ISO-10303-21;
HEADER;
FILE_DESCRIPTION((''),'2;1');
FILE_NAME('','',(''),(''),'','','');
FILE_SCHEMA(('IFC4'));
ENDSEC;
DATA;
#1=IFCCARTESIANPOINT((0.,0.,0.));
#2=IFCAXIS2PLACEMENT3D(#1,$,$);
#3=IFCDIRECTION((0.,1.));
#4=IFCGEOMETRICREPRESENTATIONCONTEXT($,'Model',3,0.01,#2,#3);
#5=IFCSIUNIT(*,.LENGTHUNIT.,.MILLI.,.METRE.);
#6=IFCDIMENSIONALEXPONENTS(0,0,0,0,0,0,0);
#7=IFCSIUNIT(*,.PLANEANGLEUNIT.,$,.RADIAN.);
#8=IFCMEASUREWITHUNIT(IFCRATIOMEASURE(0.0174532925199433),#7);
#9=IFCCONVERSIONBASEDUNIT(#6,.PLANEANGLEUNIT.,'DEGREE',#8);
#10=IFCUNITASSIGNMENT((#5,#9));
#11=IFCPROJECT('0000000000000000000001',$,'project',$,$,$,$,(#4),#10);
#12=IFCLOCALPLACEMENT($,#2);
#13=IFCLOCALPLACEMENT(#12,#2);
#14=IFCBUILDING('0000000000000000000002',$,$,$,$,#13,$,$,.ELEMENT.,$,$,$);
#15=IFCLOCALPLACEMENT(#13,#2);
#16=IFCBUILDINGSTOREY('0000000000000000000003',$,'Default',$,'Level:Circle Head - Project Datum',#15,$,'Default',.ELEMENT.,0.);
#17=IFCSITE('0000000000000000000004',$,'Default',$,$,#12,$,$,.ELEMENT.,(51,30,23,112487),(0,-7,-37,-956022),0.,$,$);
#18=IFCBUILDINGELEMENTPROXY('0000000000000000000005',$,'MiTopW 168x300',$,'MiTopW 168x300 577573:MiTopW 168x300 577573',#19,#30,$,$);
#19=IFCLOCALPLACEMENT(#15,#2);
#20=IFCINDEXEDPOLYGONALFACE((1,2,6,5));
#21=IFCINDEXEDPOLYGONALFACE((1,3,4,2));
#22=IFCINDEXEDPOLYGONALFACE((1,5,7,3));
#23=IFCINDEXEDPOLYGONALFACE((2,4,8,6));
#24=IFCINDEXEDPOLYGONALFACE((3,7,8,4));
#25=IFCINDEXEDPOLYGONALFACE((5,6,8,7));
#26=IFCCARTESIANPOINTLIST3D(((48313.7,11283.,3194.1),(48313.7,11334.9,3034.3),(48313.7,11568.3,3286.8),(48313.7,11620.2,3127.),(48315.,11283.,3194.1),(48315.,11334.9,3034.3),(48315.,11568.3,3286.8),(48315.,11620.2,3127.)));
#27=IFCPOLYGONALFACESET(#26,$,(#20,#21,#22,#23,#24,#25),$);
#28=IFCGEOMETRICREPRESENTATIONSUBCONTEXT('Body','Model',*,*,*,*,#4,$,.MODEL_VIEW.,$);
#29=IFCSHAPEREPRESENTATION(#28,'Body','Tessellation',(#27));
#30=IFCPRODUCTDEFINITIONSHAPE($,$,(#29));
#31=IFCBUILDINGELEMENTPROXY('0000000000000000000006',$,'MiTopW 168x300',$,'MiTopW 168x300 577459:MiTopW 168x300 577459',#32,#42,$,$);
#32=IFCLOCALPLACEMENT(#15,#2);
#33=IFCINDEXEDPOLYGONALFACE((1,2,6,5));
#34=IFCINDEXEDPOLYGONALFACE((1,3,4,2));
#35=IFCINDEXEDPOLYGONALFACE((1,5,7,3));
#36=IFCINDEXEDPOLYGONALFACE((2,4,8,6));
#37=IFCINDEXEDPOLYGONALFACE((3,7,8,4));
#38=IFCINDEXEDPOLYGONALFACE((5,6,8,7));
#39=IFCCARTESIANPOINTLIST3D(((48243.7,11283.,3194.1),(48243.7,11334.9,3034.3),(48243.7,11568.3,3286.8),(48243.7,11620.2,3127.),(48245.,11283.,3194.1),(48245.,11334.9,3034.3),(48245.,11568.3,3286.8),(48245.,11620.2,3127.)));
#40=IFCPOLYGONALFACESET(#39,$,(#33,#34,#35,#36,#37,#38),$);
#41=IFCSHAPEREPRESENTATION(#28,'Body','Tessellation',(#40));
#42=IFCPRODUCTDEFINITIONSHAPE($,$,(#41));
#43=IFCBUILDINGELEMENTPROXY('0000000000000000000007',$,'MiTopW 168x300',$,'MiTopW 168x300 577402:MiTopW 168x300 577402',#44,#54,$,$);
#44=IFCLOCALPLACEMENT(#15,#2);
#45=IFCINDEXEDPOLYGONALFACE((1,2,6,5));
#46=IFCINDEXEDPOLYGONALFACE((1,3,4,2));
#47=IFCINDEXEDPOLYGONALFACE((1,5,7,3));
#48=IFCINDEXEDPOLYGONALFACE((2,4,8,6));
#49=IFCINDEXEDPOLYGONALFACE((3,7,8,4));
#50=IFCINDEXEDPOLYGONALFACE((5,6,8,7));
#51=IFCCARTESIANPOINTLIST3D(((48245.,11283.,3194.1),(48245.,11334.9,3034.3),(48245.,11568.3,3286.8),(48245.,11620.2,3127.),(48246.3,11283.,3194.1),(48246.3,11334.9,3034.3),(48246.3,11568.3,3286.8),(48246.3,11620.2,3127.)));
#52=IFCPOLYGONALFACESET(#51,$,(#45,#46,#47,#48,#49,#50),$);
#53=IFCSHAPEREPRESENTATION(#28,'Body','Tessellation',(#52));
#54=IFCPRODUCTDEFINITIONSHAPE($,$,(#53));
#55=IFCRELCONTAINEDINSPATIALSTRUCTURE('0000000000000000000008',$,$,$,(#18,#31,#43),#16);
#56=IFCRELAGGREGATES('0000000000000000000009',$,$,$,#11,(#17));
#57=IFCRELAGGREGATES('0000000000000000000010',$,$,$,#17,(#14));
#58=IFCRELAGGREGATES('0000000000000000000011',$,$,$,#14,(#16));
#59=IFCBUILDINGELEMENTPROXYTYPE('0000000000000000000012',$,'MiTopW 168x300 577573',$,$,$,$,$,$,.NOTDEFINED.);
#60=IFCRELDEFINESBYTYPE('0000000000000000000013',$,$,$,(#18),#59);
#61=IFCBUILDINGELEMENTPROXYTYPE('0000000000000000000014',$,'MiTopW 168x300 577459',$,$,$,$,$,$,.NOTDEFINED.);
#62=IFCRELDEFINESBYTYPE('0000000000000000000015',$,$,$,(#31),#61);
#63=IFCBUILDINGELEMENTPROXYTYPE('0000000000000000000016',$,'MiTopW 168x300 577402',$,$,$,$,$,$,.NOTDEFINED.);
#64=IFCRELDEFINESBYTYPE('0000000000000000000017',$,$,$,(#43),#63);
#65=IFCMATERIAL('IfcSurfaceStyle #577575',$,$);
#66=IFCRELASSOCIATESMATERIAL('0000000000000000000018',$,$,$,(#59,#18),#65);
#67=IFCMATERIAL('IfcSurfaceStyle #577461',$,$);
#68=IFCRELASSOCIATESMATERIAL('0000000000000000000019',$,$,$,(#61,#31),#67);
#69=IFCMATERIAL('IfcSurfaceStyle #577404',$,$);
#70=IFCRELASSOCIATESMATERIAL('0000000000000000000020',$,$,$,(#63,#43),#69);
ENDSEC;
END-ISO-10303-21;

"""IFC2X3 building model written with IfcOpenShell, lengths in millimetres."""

from ifc_helpers import new_model, entity, si_unit, converted_unit, direction, frame, origin, place, context, subcontext, project, spatial, polyline, outline, extrude, source, transform, mapped, material, type_object, type_shapes, element, save


model = new_model("IFC2X3")

# Units and contexts
model_context = context("Model", 3, precision=0.01, world=origin(), true_north=direction((0.0, 1.0)))
body_context = subcontext(model_context, "Body", "Model", "MODEL_VIEW")
ifc_project = project(units=[si_unit("LENGTHUNIT", "METRE", prefix="MILLI"), converted_unit("PLANEANGLEUNIT", "DEGREE", entity("IfcRatioMeasure", 0.0174532925199433), si_unit("PLANEANGLEUNIT", "RADIAN"), dimensions=[0, 0, 0, 0, 0, 0, 0])], contexts=[model_context])

# Site, building, storey
site_placement = place(None, origin())
site = spatial("IfcSite", under=ifc_project, at=site_placement, Name="Default", CompositionType="ELEMENT", RefLatitude=(51, 30, 23, 112487), RefLongitude=(0, -7, -37, -956022), RefElevation=0.0)
building_placement = place(site_placement, origin())
building = spatial("IfcBuilding", under=site, at=building_placement, CompositionType="ELEMENT")
storey_placement = place(building_placement, origin())
storey = spatial("IfcBuildingStorey", under=building, at=storey_placement, Name="Default", ObjectType="Level:Circle Head - Project Datum", LongName="Default", CompositionType="ELEMENT", Elevation=0.0)

# Building element proxies
ifc_material_1 = material(Name="IfcSurfaceStyle #577575")
building_element_proxy_type_1 = type_object("IfcBuildingElementProxyType", Name="MiTopW 168x300 577573", PredefinedType="NOTDEFINED", material=ifc_material_1)
shared_shape_1 = source(origin(), body_context, "Body", "SweptSolid", [
    extrude(outline(polyline([(-150.0, -84.0), (150.0, -84.0), (150.0, 84.0), (-150.0, 84.0), (-150.0, -84.0)])), frame((150.0, 84.0, 0.0), z_axis=(0.0, 0.0, 1.0), x_axis=(-1.0, 0.0, 0.0)), (0.0, 0.0, 1.0), 1.3),
])
type_shapes(building_element_proxy_type_1, [shared_shape_1])
proxy_1_placement = place(building_placement, frame((48315.0, 11283.0, 3194.1), z_axis=(-1.0, 0.0, 0.0), x_axis=(0.0, 0.951057, 0.309017)))
element("IfcBuildingElementProxy", 1, at=proxy_1_placement, inside=storey, type_object=building_element_proxy_type_1, material=ifc_material_1, Name="MiTopW 168x300", ObjectType="MiTopW 168x300 577573:MiTopW 168x300 577573", context=body_context, shape_type="MappedRepresentation", body=[
    mapped(shared_shape_1, transform((0.0, 0.0, 0.0), scale=1.0)),
])
ifc_material_2 = material(Name="IfcSurfaceStyle #577461")
building_element_proxy_type_2 = type_object("IfcBuildingElementProxyType", Name="MiTopW 168x300 577459", PredefinedType="NOTDEFINED", material=ifc_material_2)
shared_shape_2 = source(origin(), body_context, "Body", "SweptSolid", [
    extrude(outline(polyline([(-150.0, -84.0), (150.0, -84.0), (150.0, 84.0), (-150.0, 84.0), (-150.0, -84.0)])), frame((150.0, 84.0, 0.0), z_axis=(0.0, 0.0, 1.0), x_axis=(-1.0, 0.0, 0.0)), (0.0, 0.0, 1.0), 1.3),
])
type_shapes(building_element_proxy_type_2, [shared_shape_2])
proxy_2_placement = place(building_placement, frame((48245.0, 11283.0, 3194.1), z_axis=(-1.0, 0.0, 0.0), x_axis=(0.0, 0.951057, 0.309017)))
element("IfcBuildingElementProxy", 2, at=proxy_2_placement, inside=storey, type_object=building_element_proxy_type_2, material=ifc_material_2, Name="MiTopW 168x300", ObjectType="MiTopW 168x300 577459:MiTopW 168x300 577459", context=body_context, shape_type="MappedRepresentation", body=[
    mapped(shared_shape_2, transform((0.0, 0.0, 0.0), scale=1.0)),
])
ifc_material_3 = material(Name="IfcSurfaceStyle #577404")
building_element_proxy_type_3 = type_object("IfcBuildingElementProxyType", Name="MiTopW 168x300 577402", PredefinedType="NOTDEFINED", material=ifc_material_3)
shared_shape_3 = source(origin(), body_context, "Body", "SweptSolid", [
    extrude(outline(polyline([(-150.0, -84.0), (150.0, -84.0), (150.0, 84.0), (-150.0, 84.0), (-150.0, -84.0)])), frame((150.0, 84.0, 0.0), z_axis=(0.0, 0.0, 1.0), x_axis=(-1.0, 0.0, 0.0)), (0.0, 0.0, 1.0), 1.3),
])
type_shapes(building_element_proxy_type_3, [shared_shape_3])
proxy_3_placement = place(building_placement, frame((48246.3, 11283.0, 3194.1), z_axis=(-1.0, 0.0, 0.0), x_axis=(0.0, 0.951057, 0.309017)))
element("IfcBuildingElementProxy", 3, at=proxy_3_placement, inside=storey, type_object=building_element_proxy_type_3, material=ifc_material_3, Name="MiTopW 168x300", ObjectType="MiTopW 168x300 577402:MiTopW 168x300 577402", context=body_context, shape_type="MappedRepresentation", body=[
    mapped(shared_shape_3, transform((0.0, 0.0, 0.0), scale=1.0)),
])

save(model, "model.ifc")
